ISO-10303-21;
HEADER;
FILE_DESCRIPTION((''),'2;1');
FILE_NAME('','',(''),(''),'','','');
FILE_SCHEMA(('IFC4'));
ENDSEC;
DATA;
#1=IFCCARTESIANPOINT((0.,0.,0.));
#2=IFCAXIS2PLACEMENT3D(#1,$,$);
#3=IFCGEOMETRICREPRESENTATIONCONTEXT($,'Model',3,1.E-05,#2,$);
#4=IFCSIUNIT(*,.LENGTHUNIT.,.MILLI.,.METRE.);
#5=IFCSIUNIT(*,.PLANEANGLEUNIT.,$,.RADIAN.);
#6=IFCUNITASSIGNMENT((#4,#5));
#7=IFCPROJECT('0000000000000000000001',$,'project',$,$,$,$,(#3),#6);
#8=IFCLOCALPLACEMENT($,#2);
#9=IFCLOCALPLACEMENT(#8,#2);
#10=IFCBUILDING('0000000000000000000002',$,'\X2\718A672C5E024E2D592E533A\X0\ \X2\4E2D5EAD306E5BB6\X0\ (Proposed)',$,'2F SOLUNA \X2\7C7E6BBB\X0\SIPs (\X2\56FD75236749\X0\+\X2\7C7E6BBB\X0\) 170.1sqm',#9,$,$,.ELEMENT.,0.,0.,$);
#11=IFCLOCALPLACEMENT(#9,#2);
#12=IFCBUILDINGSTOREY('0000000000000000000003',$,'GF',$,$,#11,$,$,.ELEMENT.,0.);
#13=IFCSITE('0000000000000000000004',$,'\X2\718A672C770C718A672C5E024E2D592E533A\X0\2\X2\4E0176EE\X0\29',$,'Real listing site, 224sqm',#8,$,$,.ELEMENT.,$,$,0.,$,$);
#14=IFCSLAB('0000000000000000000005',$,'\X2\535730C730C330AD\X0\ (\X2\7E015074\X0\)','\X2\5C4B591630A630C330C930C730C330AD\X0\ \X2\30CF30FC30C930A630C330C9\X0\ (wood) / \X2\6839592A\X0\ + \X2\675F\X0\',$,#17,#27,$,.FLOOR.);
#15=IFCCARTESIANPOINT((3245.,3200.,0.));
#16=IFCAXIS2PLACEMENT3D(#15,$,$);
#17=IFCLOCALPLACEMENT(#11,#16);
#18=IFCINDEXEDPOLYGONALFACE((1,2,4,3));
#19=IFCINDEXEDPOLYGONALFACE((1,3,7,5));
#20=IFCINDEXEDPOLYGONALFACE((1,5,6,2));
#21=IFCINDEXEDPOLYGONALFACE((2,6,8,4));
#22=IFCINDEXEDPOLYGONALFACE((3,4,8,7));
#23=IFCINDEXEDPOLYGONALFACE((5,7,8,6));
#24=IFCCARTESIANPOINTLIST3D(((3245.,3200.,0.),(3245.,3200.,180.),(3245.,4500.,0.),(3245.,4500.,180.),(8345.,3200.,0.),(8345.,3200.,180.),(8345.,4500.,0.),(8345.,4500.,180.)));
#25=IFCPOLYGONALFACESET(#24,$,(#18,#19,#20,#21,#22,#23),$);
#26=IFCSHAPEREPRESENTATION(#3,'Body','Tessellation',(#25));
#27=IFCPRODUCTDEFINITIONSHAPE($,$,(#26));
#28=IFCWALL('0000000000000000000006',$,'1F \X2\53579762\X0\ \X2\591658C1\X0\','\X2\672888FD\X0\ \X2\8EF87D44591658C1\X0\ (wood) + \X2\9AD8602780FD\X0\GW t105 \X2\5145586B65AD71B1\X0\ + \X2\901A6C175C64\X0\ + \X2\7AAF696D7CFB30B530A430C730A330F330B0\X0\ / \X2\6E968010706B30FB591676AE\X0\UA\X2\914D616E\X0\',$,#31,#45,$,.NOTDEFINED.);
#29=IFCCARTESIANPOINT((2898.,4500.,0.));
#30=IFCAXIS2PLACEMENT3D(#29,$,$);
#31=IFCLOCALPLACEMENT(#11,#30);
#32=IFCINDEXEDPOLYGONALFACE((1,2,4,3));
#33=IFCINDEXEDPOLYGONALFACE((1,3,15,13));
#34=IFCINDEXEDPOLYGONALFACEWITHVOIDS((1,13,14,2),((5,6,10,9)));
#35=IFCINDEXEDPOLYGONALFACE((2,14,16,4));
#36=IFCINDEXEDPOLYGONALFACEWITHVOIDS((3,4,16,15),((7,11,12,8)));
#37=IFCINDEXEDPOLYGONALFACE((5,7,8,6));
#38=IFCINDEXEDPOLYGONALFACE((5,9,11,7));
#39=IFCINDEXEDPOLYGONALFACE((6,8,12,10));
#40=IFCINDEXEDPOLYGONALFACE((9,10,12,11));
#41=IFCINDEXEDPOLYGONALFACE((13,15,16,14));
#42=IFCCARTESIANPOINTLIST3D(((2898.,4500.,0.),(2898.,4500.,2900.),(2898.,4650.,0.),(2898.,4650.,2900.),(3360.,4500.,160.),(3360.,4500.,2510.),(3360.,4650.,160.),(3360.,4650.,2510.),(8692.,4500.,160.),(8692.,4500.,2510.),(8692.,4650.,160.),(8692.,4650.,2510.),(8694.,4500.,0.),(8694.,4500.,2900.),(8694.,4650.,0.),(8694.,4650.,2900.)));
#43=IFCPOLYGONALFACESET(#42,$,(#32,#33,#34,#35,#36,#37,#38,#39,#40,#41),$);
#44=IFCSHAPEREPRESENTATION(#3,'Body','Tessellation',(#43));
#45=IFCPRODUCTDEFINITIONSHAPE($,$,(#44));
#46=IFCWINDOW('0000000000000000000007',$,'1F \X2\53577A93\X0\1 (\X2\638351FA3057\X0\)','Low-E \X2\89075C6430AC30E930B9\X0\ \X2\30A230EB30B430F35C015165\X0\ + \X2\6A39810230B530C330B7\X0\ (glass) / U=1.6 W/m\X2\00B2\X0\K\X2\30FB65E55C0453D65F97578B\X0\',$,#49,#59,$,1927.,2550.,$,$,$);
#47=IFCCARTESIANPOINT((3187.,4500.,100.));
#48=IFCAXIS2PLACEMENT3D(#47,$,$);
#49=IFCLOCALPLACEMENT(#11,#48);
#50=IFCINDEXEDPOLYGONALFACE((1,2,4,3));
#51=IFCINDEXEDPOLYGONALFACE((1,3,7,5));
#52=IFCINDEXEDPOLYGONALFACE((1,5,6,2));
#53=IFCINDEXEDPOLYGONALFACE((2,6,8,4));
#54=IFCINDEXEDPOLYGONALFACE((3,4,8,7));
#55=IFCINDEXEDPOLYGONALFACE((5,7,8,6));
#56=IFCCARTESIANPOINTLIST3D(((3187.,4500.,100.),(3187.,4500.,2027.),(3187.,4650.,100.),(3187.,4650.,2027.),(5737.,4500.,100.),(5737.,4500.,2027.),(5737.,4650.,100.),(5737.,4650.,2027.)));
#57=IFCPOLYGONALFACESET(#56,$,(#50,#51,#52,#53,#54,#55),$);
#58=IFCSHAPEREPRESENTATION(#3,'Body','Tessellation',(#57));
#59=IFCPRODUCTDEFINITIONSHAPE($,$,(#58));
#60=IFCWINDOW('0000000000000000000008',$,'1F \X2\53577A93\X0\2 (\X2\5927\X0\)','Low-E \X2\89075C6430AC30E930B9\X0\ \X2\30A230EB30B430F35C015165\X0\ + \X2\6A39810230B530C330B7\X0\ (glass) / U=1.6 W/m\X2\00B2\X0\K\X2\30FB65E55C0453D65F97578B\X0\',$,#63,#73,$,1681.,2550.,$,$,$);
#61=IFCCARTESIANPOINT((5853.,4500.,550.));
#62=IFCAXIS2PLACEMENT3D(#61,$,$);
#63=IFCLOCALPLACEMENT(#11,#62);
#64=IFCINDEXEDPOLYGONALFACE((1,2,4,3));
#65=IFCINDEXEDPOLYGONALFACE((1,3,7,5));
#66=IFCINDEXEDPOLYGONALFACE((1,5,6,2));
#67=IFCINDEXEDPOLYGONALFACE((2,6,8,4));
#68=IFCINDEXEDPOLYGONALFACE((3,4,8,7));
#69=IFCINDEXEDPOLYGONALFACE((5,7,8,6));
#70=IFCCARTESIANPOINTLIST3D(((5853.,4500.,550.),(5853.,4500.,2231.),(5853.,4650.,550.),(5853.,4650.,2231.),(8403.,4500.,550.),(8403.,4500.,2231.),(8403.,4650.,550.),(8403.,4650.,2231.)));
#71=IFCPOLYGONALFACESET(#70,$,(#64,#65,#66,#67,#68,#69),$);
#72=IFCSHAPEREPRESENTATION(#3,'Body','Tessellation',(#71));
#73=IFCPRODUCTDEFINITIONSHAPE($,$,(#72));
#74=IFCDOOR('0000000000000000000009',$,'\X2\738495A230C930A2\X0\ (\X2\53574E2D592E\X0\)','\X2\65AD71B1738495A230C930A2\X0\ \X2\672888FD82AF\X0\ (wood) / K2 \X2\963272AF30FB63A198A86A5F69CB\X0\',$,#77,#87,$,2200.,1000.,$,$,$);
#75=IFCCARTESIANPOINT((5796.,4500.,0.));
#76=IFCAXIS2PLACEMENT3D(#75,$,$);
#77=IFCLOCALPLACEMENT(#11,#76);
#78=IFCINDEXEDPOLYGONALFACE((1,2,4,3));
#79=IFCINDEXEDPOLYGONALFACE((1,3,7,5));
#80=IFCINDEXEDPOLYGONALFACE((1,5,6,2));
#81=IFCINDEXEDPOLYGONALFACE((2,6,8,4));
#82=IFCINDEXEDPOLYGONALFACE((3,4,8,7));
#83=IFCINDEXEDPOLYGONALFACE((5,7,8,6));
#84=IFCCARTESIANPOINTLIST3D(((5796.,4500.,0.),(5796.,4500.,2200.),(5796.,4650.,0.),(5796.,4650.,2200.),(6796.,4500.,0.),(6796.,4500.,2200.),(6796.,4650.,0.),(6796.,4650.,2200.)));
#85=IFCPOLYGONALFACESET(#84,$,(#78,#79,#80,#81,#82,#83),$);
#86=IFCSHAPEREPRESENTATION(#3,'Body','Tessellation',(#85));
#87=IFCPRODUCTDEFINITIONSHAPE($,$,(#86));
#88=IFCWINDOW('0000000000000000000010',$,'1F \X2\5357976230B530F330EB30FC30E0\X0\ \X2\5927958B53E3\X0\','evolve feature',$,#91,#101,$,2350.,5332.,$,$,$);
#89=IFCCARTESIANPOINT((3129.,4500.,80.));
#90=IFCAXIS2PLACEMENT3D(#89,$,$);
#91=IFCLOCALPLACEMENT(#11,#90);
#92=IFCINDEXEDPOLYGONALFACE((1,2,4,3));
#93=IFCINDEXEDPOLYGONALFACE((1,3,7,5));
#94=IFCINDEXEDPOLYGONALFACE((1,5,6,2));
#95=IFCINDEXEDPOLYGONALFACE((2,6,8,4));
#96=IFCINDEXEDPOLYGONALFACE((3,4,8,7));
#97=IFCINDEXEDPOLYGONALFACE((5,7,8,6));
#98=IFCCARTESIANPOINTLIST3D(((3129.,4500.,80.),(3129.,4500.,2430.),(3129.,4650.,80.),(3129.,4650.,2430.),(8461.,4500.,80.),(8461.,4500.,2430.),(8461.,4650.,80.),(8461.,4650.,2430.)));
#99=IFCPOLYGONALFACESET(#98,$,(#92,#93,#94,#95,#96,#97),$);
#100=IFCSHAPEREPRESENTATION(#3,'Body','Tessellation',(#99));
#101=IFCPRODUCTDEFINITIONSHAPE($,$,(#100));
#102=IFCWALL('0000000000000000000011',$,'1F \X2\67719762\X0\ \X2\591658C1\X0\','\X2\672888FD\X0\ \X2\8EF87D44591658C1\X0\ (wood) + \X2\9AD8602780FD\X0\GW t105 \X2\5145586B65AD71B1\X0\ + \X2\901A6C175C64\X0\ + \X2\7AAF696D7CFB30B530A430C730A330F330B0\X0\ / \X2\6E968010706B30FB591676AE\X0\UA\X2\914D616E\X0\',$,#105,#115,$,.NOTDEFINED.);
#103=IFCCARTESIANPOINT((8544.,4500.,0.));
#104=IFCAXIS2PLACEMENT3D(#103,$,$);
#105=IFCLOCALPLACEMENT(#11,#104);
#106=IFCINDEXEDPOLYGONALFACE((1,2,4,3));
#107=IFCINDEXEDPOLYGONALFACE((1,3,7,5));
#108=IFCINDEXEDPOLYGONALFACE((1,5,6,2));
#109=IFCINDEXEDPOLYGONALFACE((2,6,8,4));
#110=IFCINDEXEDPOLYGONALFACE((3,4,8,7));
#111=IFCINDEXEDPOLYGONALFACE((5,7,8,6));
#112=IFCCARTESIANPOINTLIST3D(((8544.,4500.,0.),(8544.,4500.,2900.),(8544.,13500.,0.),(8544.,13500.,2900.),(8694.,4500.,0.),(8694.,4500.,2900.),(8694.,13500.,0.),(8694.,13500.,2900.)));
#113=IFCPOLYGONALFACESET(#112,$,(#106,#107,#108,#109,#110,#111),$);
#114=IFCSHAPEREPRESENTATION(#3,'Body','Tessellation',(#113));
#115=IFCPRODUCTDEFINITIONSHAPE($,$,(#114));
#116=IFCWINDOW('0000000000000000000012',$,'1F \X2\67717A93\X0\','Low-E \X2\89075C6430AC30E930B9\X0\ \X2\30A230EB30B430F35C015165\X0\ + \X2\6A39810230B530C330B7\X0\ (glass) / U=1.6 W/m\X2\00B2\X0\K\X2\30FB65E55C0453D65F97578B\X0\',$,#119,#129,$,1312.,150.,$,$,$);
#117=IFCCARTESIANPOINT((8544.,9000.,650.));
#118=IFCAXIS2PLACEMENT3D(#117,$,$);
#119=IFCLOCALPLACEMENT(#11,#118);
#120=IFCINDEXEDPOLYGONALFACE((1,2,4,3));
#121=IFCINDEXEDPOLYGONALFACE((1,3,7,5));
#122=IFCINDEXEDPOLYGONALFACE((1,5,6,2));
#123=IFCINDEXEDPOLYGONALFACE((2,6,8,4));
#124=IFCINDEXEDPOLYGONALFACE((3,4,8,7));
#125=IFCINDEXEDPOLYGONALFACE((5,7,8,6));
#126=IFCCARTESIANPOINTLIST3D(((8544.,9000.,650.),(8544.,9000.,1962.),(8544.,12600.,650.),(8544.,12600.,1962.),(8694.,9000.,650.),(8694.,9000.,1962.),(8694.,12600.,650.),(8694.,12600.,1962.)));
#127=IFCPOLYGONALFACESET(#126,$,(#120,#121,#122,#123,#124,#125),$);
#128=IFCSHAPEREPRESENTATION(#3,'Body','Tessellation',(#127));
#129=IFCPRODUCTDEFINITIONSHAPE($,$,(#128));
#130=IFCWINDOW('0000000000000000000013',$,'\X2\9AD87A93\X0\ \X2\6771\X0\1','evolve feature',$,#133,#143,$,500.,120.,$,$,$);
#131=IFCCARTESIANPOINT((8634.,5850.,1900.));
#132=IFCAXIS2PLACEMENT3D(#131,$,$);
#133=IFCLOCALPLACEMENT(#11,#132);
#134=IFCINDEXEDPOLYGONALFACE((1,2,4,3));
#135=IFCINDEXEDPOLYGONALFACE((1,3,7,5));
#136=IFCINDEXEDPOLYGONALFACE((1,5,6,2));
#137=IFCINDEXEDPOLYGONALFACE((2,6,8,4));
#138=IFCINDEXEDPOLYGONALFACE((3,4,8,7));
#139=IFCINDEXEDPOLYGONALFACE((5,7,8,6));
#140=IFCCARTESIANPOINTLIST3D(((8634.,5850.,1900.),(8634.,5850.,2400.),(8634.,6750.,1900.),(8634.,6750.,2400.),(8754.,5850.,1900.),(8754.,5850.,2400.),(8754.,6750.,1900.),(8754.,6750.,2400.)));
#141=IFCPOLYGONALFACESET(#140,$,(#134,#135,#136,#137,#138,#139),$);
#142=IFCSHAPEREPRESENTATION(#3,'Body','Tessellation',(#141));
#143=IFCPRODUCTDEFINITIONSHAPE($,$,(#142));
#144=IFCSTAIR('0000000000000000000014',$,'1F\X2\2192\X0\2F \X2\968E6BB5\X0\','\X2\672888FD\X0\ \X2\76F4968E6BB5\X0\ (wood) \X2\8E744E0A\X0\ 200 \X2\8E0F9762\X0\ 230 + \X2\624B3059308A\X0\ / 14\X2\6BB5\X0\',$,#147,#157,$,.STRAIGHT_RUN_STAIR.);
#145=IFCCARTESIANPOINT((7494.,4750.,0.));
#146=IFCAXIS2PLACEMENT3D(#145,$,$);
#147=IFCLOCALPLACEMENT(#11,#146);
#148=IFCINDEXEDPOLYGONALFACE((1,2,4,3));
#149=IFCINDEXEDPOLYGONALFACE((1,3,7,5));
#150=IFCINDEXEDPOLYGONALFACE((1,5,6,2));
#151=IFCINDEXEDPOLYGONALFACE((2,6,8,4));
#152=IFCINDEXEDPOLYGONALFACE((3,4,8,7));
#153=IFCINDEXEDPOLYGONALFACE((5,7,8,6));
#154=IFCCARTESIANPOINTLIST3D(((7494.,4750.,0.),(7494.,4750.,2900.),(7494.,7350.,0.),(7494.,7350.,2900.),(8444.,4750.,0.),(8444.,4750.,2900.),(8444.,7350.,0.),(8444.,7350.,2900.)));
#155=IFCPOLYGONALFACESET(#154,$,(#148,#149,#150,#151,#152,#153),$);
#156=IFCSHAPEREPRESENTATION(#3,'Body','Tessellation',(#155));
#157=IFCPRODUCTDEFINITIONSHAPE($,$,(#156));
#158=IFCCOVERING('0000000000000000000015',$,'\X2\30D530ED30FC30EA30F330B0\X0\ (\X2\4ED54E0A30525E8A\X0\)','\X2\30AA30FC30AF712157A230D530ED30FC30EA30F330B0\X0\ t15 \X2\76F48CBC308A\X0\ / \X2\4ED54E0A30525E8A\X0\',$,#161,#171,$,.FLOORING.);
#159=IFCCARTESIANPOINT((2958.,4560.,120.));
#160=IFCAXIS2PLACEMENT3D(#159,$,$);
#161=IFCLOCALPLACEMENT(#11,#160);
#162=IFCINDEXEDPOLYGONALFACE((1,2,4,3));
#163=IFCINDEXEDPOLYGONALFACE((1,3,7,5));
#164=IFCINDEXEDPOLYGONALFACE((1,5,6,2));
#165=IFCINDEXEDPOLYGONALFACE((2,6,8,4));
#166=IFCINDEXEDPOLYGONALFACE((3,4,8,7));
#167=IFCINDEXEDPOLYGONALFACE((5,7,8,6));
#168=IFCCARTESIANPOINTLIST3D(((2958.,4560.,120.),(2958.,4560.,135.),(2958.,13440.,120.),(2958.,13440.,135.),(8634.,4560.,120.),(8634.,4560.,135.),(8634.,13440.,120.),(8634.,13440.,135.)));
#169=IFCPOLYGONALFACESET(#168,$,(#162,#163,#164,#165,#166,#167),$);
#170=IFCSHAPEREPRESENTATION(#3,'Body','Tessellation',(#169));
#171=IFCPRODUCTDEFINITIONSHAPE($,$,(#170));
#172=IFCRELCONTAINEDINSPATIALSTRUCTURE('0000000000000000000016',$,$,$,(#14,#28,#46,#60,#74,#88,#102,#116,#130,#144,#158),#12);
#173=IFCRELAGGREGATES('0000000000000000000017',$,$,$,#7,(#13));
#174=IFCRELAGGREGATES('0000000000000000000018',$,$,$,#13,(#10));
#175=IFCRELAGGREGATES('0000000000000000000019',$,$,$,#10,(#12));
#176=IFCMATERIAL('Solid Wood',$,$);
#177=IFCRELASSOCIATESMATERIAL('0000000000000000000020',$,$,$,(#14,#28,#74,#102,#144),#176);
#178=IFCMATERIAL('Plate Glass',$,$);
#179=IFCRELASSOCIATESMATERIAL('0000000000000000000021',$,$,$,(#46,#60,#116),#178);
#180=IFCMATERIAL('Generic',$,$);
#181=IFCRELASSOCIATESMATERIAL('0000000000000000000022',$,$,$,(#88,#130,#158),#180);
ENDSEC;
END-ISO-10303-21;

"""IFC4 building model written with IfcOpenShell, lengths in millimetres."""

from ifc_helpers import new_model, si_unit, frame, frame_2d, origin, place, context, project, spatial, rectangle, extrude, material, element, fill, save


model = new_model("IFC4")

# Units and contexts
model_context = context("Model", 3, precision=1e-05, world=origin())
ifc_project = project(units=[si_unit("LENGTHUNIT", "METRE", prefix="MILLI"), si_unit("PLANEANGLEUNIT", "RADIAN")], contexts=[model_context])

# Site, building, storey
site_placement = place(None, origin())
site = spatial("IfcSite", under=ifc_project, at=site_placement, Name="熊本県熊本市中央区2丁目29", ObjectType="Real listing site, 224sqm", CompositionType="ELEMENT", RefElevation=0.0)
building_placement = place(site_placement, origin())
building = spatial("IfcBuilding", under=site, at=building_placement, Name="熊本市中央区 中庭の家 (Proposed)", ObjectType="2F SOLUNA 籾殻SIPs (国産杉+籾殻) 170.1sqm", CompositionType="ELEMENT", ElevationOfRefHeight=0.0, ElevationOfTerrain=0.0)
storey_placement = place(building_placement, origin())
storey = spatial("IfcBuildingStorey", under=building, at=storey_placement, Name="GF", CompositionType="ELEMENT", Elevation=0.0)

# Slab
ifc_material_1 = material(Name="Solid Wood")
slab_1_placement = place(storey_placement, frame((3245.0, 3200.0, 0.0)))
element("IfcSlab", 1, at=slab_1_placement, inside=storey, material=ifc_material_1, Name="南デッキ (縁側)", Description="屋外ウッドデッキ ハードウッド (wood) / 根太 + 束", PredefinedType="FLOOR", context=model_context, shape_type="SweptSolid", body=[
    extrude(rectangle(XDim=5100.0, YDim=1300.0, at=frame_2d((2550.0, 650.0))), frame((3245.0, 3200.0, 0.0)), (0.0, 0.0, 1.0), 180.0),
])
ifc_material_2 = material(Name="Generic")

# Wall, openings, windows, door
wall_1_placement = place(storey_placement, frame((2898.0, 4500.0, 0.0)))
wall_1 = element("IfcWall", 2, at=wall_1_placement, inside=storey, material=ifc_material_1, Name="1F 南面 外壁", Description="木製 軸組外壁 (wood) + 高性能GW t105 充填断熱 + 通気層 + 窯業系サイディング / 準耐火・外皮UA配慮", PredefinedType="NOTDEFINED", context=model_context, shape_type="SweptSolid", body=[
    extrude(rectangle(XDim=5796.0, YDim=150.0, at=frame_2d((2898.0, 75.0))), frame((2898.0, 4500.0, 0.0)), (0.0, 0.0, 1.0), 2900.0),
])
opening_1_placement = place(storey_placement, frame((3187.0, 4500.0, 100.0)))
opening_1 = element("IfcOpeningElement", 3, at=opening_1_placement, cuts=wall_1, PredefinedType="NOTDEFINED", context=model_context, shape_type="SweptSolid", body=[
    extrude(rectangle(XDim=2550.0, YDim=150.0, at=frame_2d((1275.0, 75.0))), frame((3187.0, 4500.0, 100.0)), (0.0, 0.0, 1.0), 1927.0),
])
opening_2_placement = place(storey_placement, frame((5853.0, 4500.0, 550.0)))
opening_2 = element("IfcOpeningElement", 4, at=opening_2_placement, cuts=wall_1, PredefinedType="NOTDEFINED", context=model_context, shape_type="SweptSolid", body=[
    extrude(rectangle(XDim=2550.0, YDim=150.0, at=frame_2d((1275.0, 75.0))), frame((5853.0, 4500.0, 550.0)), (0.0, 0.0, 1.0), 1681.0),
])
opening_3_placement = place(storey_placement, frame((5796.0, 4500.0, 0.0)))
opening_3 = element("IfcOpeningElement", 5, at=opening_3_placement, cuts=wall_1, PredefinedType="NOTDEFINED", context=model_context, shape_type="SweptSolid", body=[
    extrude(rectangle(XDim=1000.0, YDim=150.0, at=frame_2d((500.0, 75.0))), frame((5796.0, 4500.0, 0.0)), (0.0, 0.0, 1.0), 2200.0),
])
opening_4_placement = place(storey_placement, frame((3129.0, 4500.0, 80.0)))
opening_4 = element("IfcOpeningElement", 6, at=opening_4_placement, cuts=wall_1, PredefinedType="NOTDEFINED", context=model_context, shape_type="SweptSolid", body=[
    extrude(rectangle(XDim=5332.0, YDim=150.0, at=frame_2d((2666.0, 75.0))), frame((3129.0, 4500.0, 80.0)), (0.0, 0.0, 1.0), 2350.0),
])
ifc_material_3 = material(Name="Plate Glass")
window_1_placement = place(storey_placement, frame((3187.0, 4500.0, 100.0)))
window_1 = element("IfcWindow", 7, at=window_1_placement, inside=storey, material=ifc_material_3, Name="1F 南窓1 (掃出し)", Description="Low-E 複層ガラス アルゴン封入 + 樹脂サッシ (glass) / U=1.6 W/m²K・日射取得型", OverallHeight=1927.0, OverallWidth=2550.0, context=model_context, shape_type="SweptSolid", body=[
    extrude(rectangle(XDim=2550.0, YDim=150.0, at=frame_2d((1275.0, 75.0))), frame((3187.0, 4500.0, 100.0)), (0.0, 0.0, 1.0), 1927.0),
])
fill(opening_1, window_1)
window_2_placement = place(storey_placement, frame((5853.0, 4500.0, 550.0)))
window_2 = element("IfcWindow", 8, at=window_2_placement, inside=storey, material=ifc_material_3, Name="1F 南窓2 (大)", Description="Low-E 複層ガラス アルゴン封入 + 樹脂サッシ (glass) / U=1.6 W/m²K・日射取得型", OverallHeight=1681.0, OverallWidth=2550.0, context=model_context, shape_type="SweptSolid", body=[
    extrude(rectangle(XDim=2550.0, YDim=150.0, at=frame_2d((1275.0, 75.0))), frame((5853.0, 4500.0, 550.0)), (0.0, 0.0, 1.0), 1681.0),
])
fill(opening_2, window_2)
door_placement = place(storey_placement, frame((5796.0, 4500.0, 0.0)))
door = element("IfcDoor", 9, at=door_placement, inside=storey, material=ifc_material_1, Name="玄関ドア (南中央)", Description="断熱玄関ドア 木製芯 (wood) / K2 防犯・採風機構", OverallHeight=2200.0, OverallWidth=1000.0, context=model_context, shape_type="SweptSolid", body=[
    extrude(rectangle(XDim=1000.0, YDim=150.0, at=frame_2d((500.0, 75.0))), frame((5796.0, 4500.0, 0.0)), (0.0, 0.0, 1.0), 2200.0),
])
fill(opening_3, door)
window_3_placement = place(storey_placement, frame((3129.0, 4500.0, 80.0)))
window_3 = element("IfcWindow", 10, at=window_3_placement, inside=storey, material=ifc_material_2, Name="1F 南面サンルーム 大開口", Description="evolve feature", OverallHeight=2350.0, OverallWidth=5332.0, context=model_context, shape_type="SweptSolid", body=[
    extrude(rectangle(XDim=5332.0, YDim=150.0, at=frame_2d((2666.0, 75.0))), frame((3129.0, 4500.0, 80.0)), (0.0, 0.0, 1.0), 2350.0),
])
fill(opening_4, window_3)

# Wall, openings, windows
wall_2_placement = place(storey_placement, frame((8544.0, 4500.0, 0.0)))
wall_2 = element("IfcWall", 11, at=wall_2_placement, inside=storey, material=ifc_material_1, Name="1F 東面 外壁", Description="木製 軸組外壁 (wood) + 高性能GW t105 充填断熱 + 通気層 + 窯業系サイディング / 準耐火・外皮UA配慮", PredefinedType="NOTDEFINED", context=model_context, shape_type="SweptSolid", body=[
    extrude(rectangle(XDim=150.0, YDim=9000.0, at=frame_2d((75.0, 4500.0))), frame((8544.0, 4500.0, 0.0)), (0.0, 0.0, 1.0), 2900.0),
])
opening_5_placement = place(storey_placement, frame((8544.0, 9000.0, 650.0)))
opening_5 = element("IfcOpeningElement", 12, at=opening_5_placement, cuts=wall_2, PredefinedType="NOTDEFINED", context=model_context, shape_type="SweptSolid", body=[
    extrude(rectangle(XDim=150.0, YDim=3600.0, at=frame_2d((75.0, 1800.0))), frame((8544.0, 9000.0, 650.0)), (0.0, 0.0, 1.0), 1312.0),
])
opening_6_placement = place(storey_placement, frame((8634.0, 5850.0, 1900.0)))
opening_6 = element("IfcOpeningElement", 13, at=opening_6_placement, cuts=wall_2, PredefinedType="NOTDEFINED", context=model_context, shape_type="SweptSolid", body=[
    extrude(rectangle(XDim=120.0, YDim=900.0, at=frame_2d((60.0, 450.0))), frame((8634.0, 5850.0, 1900.0)), (0.0, 0.0, 1.0), 500.0),
])
window_4_placement = place(storey_placement, frame((8544.0, 9000.0, 650.0)))
window_4 = element("IfcWindow", 14, at=window_4_placement, inside=storey, material=ifc_material_3, Name="1F 東窓", Description="Low-E 複層ガラス アルゴン封入 + 樹脂サッシ (glass) / U=1.6 W/m²K・日射取得型", OverallHeight=1312.0, OverallWidth=150.0, context=model_context, shape_type="SweptSolid", body=[
    extrude(rectangle(XDim=150.0, YDim=3600.0, at=frame_2d((75.0, 1800.0))), frame((8544.0, 9000.0, 650.0)), (0.0, 0.0, 1.0), 1312.0),
])
fill(opening_5, window_4)
window_5_placement = place(storey_placement, frame((8634.0, 5850.0, 1900.0)))
window_5 = element("IfcWindow", 15, at=window_5_placement, inside=storey, material=ifc_material_2, Name="高窓 東1", Description="evolve feature", OverallHeight=500.0, OverallWidth=120.0, context=model_context, shape_type="SweptSolid", body=[
    extrude(rectangle(XDim=120.0, YDim=900.0, at=frame_2d((60.0, 450.0))), frame((8634.0, 5850.0, 1900.0)), (0.0, 0.0, 1.0), 500.0),
])
fill(opening_6, window_5)

# Stair
stair_placement = place(storey_placement, frame((7494.0, 4750.0, 0.0)))
element("IfcStair", 16, at=stair_placement, inside=storey, material=ifc_material_1, Name="1F→2F 階段", Description="木製 直階段 (wood) 蹴上 200 踏面 230 + 手すり / 14段", PredefinedType="STRAIGHT_RUN_STAIR", context=model_context, shape_type="SweptSolid", body=[
    extrude(rectangle(XDim=950.0, YDim=2600.0, at=frame_2d((475.0, 1300.0))), frame((7494.0, 4750.0, 0.0)), (0.0, 0.0, 1.0), 2900.0),
])

# Covering
covering_placement = place(storey_placement, frame((2958.0, 4560.0, 120.0)))
element("IfcCovering", 17, at=covering_placement, inside=storey, material=ifc_material_2, Name="フローリング (仕上げ床)", Description="オーク無垢フローリング t15 直貼り / 仕上げ床", PredefinedType="FLOORING", context=model_context, shape_type="SweptSolid", body=[
    extrude(rectangle(XDim=5676.0, YDim=8880.0, at=frame_2d((2838.0, 4440.0))), frame((2958.0, 4560.0, 120.0)), (0.0, 0.0, 1.0), 15.0),
])

save(model, "model.ifc")
